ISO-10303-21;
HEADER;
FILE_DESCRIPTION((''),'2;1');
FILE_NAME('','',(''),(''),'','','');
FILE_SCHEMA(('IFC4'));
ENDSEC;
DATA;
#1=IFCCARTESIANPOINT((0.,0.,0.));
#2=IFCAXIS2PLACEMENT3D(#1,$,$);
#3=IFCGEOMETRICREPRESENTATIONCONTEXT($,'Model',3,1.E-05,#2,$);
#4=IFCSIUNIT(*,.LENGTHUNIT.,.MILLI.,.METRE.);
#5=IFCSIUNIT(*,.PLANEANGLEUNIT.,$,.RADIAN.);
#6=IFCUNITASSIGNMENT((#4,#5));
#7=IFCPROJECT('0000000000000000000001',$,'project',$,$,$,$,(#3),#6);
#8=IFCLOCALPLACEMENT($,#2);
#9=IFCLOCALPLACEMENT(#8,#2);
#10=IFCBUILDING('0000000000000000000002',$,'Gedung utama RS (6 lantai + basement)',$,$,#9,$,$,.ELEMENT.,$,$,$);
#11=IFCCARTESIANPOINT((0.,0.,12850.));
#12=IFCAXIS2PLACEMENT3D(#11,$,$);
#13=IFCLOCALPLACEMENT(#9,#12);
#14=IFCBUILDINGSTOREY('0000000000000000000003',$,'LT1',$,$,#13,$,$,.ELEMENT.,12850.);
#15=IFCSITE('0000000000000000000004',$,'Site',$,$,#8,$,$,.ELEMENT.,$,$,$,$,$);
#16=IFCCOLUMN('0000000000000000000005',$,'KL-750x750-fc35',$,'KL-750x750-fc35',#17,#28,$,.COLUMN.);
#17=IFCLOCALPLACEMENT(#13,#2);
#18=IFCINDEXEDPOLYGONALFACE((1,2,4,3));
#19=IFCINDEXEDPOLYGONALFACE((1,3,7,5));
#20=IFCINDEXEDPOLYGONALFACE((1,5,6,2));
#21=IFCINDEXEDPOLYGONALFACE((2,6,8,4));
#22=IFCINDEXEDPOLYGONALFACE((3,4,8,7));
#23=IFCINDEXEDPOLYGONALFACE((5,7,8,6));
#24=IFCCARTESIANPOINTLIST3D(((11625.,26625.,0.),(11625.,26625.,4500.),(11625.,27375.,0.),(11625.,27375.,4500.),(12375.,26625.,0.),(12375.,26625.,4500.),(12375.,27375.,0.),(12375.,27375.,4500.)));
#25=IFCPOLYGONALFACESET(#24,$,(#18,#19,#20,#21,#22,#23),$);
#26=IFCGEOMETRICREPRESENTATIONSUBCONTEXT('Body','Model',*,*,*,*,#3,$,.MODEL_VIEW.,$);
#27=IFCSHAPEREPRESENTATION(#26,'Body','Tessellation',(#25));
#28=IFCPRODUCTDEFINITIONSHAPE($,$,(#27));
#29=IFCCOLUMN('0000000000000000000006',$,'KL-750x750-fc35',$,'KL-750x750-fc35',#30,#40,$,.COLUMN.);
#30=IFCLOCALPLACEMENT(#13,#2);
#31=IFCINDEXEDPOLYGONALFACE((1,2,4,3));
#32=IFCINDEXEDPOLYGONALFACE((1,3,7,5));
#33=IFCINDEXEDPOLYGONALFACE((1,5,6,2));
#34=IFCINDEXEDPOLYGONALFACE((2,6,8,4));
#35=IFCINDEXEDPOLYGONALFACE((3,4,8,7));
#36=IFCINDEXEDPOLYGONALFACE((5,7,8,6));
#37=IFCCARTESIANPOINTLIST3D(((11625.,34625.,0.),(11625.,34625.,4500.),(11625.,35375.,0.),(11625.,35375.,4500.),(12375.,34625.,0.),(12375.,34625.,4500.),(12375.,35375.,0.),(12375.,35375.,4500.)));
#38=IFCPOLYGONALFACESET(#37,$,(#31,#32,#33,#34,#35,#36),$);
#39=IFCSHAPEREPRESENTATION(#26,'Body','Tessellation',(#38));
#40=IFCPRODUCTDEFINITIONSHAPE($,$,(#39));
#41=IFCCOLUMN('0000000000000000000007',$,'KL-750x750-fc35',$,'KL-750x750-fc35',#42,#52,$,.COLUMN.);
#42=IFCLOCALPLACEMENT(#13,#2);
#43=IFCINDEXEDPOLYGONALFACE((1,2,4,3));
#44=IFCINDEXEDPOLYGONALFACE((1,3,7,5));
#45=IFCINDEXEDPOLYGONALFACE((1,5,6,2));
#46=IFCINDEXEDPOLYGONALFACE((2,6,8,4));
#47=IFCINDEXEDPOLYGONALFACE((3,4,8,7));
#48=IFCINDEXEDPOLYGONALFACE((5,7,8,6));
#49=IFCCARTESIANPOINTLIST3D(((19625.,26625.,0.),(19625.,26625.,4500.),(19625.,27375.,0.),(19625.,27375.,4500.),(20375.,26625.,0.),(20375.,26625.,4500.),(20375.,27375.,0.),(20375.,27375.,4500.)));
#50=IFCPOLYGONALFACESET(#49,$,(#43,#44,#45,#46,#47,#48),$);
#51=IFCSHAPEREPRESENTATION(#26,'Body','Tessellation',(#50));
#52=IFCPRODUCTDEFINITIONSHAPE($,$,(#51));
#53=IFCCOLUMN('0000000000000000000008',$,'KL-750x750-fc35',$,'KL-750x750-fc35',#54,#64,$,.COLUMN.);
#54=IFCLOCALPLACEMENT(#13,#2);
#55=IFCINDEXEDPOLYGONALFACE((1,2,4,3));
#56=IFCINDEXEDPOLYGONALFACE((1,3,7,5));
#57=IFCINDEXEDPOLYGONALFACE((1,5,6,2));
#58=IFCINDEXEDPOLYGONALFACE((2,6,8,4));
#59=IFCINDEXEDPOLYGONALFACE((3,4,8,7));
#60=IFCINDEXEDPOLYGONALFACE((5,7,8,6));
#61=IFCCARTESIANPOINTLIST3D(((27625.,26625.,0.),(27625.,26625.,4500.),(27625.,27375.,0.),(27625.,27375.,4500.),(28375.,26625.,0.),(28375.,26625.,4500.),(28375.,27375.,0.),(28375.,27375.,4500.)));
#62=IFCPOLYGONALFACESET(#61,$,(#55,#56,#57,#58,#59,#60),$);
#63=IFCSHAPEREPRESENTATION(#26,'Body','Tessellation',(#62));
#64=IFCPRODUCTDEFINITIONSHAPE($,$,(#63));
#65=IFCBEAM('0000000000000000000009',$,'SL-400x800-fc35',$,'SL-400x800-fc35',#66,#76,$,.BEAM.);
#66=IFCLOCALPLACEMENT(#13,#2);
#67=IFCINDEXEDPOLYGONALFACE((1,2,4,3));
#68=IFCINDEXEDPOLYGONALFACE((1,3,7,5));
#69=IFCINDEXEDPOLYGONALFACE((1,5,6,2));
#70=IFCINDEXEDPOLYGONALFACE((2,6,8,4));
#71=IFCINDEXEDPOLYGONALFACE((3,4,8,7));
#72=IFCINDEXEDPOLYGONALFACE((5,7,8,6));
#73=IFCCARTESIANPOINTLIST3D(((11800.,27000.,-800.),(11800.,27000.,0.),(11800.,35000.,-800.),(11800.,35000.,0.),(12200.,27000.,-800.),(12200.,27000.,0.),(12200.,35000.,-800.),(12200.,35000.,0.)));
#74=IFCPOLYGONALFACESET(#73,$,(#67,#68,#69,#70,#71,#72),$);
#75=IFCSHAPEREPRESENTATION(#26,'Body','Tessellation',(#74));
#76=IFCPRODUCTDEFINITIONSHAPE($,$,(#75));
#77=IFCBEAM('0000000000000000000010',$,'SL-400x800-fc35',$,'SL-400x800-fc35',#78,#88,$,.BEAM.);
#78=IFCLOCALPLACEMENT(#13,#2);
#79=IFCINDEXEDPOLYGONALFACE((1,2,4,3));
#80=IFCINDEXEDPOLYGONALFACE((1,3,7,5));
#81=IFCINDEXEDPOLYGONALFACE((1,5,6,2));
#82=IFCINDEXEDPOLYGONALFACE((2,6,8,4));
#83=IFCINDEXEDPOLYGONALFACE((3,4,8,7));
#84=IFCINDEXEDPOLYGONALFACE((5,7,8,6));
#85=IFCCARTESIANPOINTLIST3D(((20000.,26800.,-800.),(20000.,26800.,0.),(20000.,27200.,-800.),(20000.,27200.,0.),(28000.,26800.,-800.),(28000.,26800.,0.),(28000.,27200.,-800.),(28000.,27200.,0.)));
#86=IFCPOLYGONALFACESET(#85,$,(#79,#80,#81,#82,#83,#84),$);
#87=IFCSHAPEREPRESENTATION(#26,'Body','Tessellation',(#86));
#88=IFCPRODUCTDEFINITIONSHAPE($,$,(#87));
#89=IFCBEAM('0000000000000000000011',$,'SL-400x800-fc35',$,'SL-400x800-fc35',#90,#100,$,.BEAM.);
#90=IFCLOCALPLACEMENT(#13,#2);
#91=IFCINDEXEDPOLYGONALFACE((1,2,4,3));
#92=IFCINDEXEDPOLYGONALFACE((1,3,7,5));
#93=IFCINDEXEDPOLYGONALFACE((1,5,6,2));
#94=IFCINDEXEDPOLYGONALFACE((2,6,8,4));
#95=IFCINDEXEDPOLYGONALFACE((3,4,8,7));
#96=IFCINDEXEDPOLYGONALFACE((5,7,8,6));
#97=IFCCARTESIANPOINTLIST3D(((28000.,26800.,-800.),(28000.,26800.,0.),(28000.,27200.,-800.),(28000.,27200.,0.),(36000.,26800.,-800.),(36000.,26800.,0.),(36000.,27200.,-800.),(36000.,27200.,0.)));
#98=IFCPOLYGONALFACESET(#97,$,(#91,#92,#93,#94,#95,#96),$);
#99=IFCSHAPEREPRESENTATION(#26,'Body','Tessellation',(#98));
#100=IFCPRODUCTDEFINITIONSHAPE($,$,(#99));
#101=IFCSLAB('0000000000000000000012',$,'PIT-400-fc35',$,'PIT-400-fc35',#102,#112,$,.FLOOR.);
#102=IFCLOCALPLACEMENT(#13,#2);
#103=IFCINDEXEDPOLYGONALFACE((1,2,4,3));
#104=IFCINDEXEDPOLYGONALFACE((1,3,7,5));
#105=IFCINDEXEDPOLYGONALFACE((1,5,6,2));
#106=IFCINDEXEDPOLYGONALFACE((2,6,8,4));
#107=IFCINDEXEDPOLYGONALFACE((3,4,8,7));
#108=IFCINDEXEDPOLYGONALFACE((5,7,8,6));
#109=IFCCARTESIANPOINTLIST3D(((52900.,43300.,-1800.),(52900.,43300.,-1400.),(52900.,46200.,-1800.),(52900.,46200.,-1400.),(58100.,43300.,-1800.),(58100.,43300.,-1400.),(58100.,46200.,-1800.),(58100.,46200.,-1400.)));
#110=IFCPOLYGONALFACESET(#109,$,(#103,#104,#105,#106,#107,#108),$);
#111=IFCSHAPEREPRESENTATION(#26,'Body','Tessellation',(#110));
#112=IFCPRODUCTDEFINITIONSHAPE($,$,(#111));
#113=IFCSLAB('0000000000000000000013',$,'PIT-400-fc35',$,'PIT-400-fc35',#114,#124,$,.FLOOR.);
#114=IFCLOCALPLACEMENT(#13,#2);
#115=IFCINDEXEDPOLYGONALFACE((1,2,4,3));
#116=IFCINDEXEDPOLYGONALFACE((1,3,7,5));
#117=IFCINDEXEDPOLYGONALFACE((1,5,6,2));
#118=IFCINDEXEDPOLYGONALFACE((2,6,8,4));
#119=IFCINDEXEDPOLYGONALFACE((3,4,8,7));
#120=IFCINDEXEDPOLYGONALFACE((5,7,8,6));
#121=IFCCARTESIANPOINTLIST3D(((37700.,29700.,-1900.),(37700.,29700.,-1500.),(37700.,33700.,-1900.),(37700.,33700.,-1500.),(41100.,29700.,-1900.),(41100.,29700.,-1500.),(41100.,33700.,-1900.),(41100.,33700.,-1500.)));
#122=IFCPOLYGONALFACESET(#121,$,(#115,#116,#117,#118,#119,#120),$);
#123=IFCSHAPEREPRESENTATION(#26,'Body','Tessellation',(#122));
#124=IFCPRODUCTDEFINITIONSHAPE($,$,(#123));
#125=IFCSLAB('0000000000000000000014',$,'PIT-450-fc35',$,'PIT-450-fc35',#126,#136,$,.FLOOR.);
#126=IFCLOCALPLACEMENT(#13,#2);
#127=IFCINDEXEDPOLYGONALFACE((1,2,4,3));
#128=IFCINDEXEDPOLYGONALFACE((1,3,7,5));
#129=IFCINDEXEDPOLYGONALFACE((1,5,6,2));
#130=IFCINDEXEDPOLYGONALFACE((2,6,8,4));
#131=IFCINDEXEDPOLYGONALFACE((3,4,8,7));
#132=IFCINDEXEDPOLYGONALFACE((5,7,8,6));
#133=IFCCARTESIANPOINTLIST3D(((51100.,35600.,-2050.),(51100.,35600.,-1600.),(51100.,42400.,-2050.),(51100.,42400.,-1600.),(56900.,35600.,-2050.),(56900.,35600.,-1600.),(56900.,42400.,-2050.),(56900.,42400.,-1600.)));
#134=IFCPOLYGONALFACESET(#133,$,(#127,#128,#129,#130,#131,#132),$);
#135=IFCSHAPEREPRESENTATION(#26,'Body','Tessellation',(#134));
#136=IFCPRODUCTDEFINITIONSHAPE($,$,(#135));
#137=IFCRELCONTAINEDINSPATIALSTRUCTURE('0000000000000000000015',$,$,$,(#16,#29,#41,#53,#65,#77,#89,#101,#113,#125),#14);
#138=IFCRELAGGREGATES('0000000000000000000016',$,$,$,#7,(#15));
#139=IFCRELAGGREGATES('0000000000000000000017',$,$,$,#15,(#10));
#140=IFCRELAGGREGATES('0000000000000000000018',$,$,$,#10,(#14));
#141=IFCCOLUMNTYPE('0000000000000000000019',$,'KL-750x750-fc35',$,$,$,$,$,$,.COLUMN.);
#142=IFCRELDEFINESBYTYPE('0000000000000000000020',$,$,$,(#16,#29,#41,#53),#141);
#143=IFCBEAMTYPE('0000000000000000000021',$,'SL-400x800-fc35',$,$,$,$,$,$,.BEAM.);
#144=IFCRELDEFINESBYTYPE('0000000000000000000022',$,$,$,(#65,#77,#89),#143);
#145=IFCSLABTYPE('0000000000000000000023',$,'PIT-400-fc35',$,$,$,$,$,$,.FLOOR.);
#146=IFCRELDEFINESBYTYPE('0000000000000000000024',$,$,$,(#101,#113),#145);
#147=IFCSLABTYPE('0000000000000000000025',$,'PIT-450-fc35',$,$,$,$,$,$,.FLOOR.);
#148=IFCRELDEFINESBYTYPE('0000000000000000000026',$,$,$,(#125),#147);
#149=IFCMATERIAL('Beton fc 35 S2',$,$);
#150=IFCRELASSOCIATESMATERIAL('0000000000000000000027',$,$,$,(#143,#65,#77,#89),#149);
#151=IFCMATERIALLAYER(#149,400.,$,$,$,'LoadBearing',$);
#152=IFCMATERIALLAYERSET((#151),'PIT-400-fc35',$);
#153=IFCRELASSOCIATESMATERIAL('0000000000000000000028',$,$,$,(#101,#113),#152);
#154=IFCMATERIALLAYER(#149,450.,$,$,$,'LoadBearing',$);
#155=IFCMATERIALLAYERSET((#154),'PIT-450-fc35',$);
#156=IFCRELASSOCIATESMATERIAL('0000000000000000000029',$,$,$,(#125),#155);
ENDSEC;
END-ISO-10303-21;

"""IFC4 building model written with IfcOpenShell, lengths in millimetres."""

from ifc_helpers import new_model, si_unit, frame, origin, origin_2d, place, context, subcontext, project, spatial, polyline, rectangle, outline, extrude, material, layer, layer_set, layer_usage, material_profile, profile_set, profile_usage, type_object, element, save


model = new_model("IFC4")

# Units and contexts
model_context = context("Model", 3, precision=1e-05, world=origin())
body_context = subcontext(model_context, "Body", "Model", "MODEL_VIEW")
ifc_project = project(units=[si_unit("LENGTHUNIT", "METRE", prefix="MILLI"), si_unit("PLANEANGLEUNIT", "RADIAN")], contexts=[model_context])

# Site, building, storey
site_placement = place(None, origin())
site = spatial("IfcSite", under=ifc_project, at=site_placement, Name="Site", CompositionType="ELEMENT")
building_placement = place(site_placement, origin())
building = spatial("IfcBuilding", under=site, at=building_placement, Name="Gedung utama RS (6 lantai + basement)", CompositionType="ELEMENT")
storey_placement = place(building_placement, frame((0.0, 0.0, 12850.0)))
storey = spatial("IfcBuildingStorey", under=building, at=storey_placement, Name="LT1", CompositionType="ELEMENT", Elevation=12850.0)

# Columns
ifc_material_profile_1 = material_profile(None, rectangle(XDim=750.0, YDim=750.0, at=origin_2d()), Name="KL-750x750-fc35")
ifc_profile_set_1 = profile_set([ifc_material_profile_1], Name="KL-750x750-fc35")
ifc_profile_usage_1 = profile_usage(ifc_profile_set_1, cardinal=5)
column_type = type_object("IfcColumnType", Name="KL-750x750-fc35", PredefinedType="COLUMN", material=ifc_profile_set_1)
for number, where, z_axis, x_axis, name in (
    (1, (12000.0, 27000.0, 0.0), (0.0, 0.0, 1.0), (1.0, 0.0, 0.0), "KL-750x750-fc35"),
    (2, (12000.0, 35000.0, 0.0), (0.0, 0.0, 1.0), (1.0, 0.0, 0.0), "KL-750x750-fc35"),
    (3, (20000.0, 27000.0, 0.0), (0.0, 0.0, 1.0), (1.0, 0.0, 0.0), "KL-750x750-fc35"),
    (4, (28000.0, 27000.0, 0.0), (0.0, 0.0, 1.0), (1.0, 0.0, 0.0), "KL-750x750-fc35"),
):
    element("IfcColumn", number, at=place(storey_placement, frame(where, z_axis=z_axis, x_axis=x_axis)), inside=storey, type_object=column_type, material=ifc_profile_usage_1, Name=name, ObjectType="KL-750x750-fc35", PredefinedType="COLUMN", context=body_context, shape_type="SweptSolid", body=[
        extrude(rectangle(XDim=750.0, YDim=750.0, at=origin_2d()), origin(), (0.0, 0.0, 1.0), 4500.0),
    ])

# Beams
ifc_material_1 = material(Name="Beton fc 35 S2")
ifc_material_profile_2 = material_profile(ifc_material_1, rectangle(XDim=400.0, YDim=800.0, at=origin_2d()), Name="SL-400x800-fc35")
ifc_profile_set_2 = profile_set([ifc_material_profile_2], Name="SL-400x800-fc35")
ifc_profile_usage_2 = profile_usage(ifc_profile_set_2, cardinal=8)
beam_type = type_object("IfcBeamType", Name="SL-400x800-fc35", PredefinedType="BEAM", material=ifc_profile_set_2)
beam_placement = place(storey_placement, frame((12000.0, 27000.0, -400.0)))
element("IfcBeam", 5, at=beam_placement, inside=storey, type_object=beam_type, material=ifc_profile_usage_2, Name="SL-400x800-fc35", ObjectType="SL-400x800-fc35", PredefinedType="BEAM", context=body_context, shape_type="SweptSolid", body=[
    extrude(rectangle(XDim=400.0, YDim=800.0, at=origin_2d()), frame((0.0, 0.0, 0.0), z_axis=(0.0, 1.0, 0.0), x_axis=(-1.0, 0.0, 0.0)), (0.0, 0.0, 1.0), 8000.0),
])
for number, where, name in (
    (6, (20000.0, 27000.0, -400.0), "SL-400x800-fc35"),
    (7, (28000.0, 27000.0, -400.0), "SL-400x800-fc35"),
):
    element("IfcBeam", number, at=place(storey_placement, frame(where)), inside=storey, type_object=beam_type, material=ifc_profile_usage_2, Name=name, ObjectType="SL-400x800-fc35", PredefinedType="BEAM", context=body_context, shape_type="SweptSolid", body=[
        extrude(rectangle(XDim=400.0, YDim=800.0, at=origin_2d()), frame((0.0, 0.0, 0.0), z_axis=(1.0, 0.0, 0.0), x_axis=(0.0, 1.0, 0.0)), (0.0, 0.0, 1.0), 8000.0),
    ])

# Slabs
ifc_layer_1 = layer(ifc_material_1, 400.0, Category="LoadBearing")
ifc_layer_set_1 = layer_set([ifc_layer_1], Name="PIT-400-fc35")
ifc_layer_usage_1 = layer_usage(ifc_layer_set_1, "AXIS3", "NEGATIVE", -1400.0)
slab_type_1 = type_object("IfcSlabType", Name="PIT-400-fc35", PredefinedType="FLOOR")
slab_1_placement = place(storey_placement, origin())
element("IfcSlab", 8, at=slab_1_placement, inside=storey, type_object=slab_type_1, material=ifc_layer_usage_1, Name="PIT-400-fc35", ObjectType="PIT-400-fc35", PredefinedType="FLOOR", context=body_context, shape_type="SweptSolid", body=[
    extrude(outline(polyline([(58100.0, 43300.0), (58100.0, 46200.0), (52900.0, 46200.0), (52900.0, 43300.0), (58100.0, 43300.0)])), frame((0.0, 0.0, -1800.0)), (0.0, 0.0, 1.0), 400.0),
])
ifc_layer_usage_2 = layer_usage(ifc_layer_set_1, "AXIS3", "NEGATIVE", -1500.0)
slab_2_placement = place(storey_placement, origin())
element("IfcSlab", 9, at=slab_2_placement, inside=storey, type_object=slab_type_1, material=ifc_layer_usage_2, Name="PIT-400-fc35", ObjectType="PIT-400-fc35", PredefinedType="FLOOR", context=body_context, shape_type="SweptSolid", body=[
    extrude(outline(polyline([(41100.0, 29700.0), (41100.0, 33700.0), (37700.0, 33700.0), (37700.0, 29700.0), (41100.0, 29700.0)])), frame((0.0, 0.0, -1900.0)), (0.0, 0.0, 1.0), 400.0),
])
ifc_layer_2 = layer(ifc_material_1, 450.0, Category="LoadBearing")
ifc_layer_set_2 = layer_set([ifc_layer_2], Name="PIT-450-fc35")
ifc_layer_usage_3 = layer_usage(ifc_layer_set_2, "AXIS3", "NEGATIVE", -1600.0)
slab_type_2 = type_object("IfcSlabType", Name="PIT-450-fc35", PredefinedType="FLOOR")
slab_3_placement = place(storey_placement, origin())
element("IfcSlab", 10, at=slab_3_placement, inside=storey, type_object=slab_type_2, material=ifc_layer_usage_3, Name="PIT-450-fc35", ObjectType="PIT-450-fc35", PredefinedType="FLOOR", context=body_context, shape_type="SweptSolid", body=[
    extrude(outline(polyline([(56900.0, 35600.0), (56900.0, 42400.0), (51100.0, 42400.0), (51100.0, 35600.0), (56900.0, 35600.0)])), frame((0.0, 0.0, -2050.0)), (0.0, 0.0, 1.0), 450.0),
])

save(model, "model.ifc")
